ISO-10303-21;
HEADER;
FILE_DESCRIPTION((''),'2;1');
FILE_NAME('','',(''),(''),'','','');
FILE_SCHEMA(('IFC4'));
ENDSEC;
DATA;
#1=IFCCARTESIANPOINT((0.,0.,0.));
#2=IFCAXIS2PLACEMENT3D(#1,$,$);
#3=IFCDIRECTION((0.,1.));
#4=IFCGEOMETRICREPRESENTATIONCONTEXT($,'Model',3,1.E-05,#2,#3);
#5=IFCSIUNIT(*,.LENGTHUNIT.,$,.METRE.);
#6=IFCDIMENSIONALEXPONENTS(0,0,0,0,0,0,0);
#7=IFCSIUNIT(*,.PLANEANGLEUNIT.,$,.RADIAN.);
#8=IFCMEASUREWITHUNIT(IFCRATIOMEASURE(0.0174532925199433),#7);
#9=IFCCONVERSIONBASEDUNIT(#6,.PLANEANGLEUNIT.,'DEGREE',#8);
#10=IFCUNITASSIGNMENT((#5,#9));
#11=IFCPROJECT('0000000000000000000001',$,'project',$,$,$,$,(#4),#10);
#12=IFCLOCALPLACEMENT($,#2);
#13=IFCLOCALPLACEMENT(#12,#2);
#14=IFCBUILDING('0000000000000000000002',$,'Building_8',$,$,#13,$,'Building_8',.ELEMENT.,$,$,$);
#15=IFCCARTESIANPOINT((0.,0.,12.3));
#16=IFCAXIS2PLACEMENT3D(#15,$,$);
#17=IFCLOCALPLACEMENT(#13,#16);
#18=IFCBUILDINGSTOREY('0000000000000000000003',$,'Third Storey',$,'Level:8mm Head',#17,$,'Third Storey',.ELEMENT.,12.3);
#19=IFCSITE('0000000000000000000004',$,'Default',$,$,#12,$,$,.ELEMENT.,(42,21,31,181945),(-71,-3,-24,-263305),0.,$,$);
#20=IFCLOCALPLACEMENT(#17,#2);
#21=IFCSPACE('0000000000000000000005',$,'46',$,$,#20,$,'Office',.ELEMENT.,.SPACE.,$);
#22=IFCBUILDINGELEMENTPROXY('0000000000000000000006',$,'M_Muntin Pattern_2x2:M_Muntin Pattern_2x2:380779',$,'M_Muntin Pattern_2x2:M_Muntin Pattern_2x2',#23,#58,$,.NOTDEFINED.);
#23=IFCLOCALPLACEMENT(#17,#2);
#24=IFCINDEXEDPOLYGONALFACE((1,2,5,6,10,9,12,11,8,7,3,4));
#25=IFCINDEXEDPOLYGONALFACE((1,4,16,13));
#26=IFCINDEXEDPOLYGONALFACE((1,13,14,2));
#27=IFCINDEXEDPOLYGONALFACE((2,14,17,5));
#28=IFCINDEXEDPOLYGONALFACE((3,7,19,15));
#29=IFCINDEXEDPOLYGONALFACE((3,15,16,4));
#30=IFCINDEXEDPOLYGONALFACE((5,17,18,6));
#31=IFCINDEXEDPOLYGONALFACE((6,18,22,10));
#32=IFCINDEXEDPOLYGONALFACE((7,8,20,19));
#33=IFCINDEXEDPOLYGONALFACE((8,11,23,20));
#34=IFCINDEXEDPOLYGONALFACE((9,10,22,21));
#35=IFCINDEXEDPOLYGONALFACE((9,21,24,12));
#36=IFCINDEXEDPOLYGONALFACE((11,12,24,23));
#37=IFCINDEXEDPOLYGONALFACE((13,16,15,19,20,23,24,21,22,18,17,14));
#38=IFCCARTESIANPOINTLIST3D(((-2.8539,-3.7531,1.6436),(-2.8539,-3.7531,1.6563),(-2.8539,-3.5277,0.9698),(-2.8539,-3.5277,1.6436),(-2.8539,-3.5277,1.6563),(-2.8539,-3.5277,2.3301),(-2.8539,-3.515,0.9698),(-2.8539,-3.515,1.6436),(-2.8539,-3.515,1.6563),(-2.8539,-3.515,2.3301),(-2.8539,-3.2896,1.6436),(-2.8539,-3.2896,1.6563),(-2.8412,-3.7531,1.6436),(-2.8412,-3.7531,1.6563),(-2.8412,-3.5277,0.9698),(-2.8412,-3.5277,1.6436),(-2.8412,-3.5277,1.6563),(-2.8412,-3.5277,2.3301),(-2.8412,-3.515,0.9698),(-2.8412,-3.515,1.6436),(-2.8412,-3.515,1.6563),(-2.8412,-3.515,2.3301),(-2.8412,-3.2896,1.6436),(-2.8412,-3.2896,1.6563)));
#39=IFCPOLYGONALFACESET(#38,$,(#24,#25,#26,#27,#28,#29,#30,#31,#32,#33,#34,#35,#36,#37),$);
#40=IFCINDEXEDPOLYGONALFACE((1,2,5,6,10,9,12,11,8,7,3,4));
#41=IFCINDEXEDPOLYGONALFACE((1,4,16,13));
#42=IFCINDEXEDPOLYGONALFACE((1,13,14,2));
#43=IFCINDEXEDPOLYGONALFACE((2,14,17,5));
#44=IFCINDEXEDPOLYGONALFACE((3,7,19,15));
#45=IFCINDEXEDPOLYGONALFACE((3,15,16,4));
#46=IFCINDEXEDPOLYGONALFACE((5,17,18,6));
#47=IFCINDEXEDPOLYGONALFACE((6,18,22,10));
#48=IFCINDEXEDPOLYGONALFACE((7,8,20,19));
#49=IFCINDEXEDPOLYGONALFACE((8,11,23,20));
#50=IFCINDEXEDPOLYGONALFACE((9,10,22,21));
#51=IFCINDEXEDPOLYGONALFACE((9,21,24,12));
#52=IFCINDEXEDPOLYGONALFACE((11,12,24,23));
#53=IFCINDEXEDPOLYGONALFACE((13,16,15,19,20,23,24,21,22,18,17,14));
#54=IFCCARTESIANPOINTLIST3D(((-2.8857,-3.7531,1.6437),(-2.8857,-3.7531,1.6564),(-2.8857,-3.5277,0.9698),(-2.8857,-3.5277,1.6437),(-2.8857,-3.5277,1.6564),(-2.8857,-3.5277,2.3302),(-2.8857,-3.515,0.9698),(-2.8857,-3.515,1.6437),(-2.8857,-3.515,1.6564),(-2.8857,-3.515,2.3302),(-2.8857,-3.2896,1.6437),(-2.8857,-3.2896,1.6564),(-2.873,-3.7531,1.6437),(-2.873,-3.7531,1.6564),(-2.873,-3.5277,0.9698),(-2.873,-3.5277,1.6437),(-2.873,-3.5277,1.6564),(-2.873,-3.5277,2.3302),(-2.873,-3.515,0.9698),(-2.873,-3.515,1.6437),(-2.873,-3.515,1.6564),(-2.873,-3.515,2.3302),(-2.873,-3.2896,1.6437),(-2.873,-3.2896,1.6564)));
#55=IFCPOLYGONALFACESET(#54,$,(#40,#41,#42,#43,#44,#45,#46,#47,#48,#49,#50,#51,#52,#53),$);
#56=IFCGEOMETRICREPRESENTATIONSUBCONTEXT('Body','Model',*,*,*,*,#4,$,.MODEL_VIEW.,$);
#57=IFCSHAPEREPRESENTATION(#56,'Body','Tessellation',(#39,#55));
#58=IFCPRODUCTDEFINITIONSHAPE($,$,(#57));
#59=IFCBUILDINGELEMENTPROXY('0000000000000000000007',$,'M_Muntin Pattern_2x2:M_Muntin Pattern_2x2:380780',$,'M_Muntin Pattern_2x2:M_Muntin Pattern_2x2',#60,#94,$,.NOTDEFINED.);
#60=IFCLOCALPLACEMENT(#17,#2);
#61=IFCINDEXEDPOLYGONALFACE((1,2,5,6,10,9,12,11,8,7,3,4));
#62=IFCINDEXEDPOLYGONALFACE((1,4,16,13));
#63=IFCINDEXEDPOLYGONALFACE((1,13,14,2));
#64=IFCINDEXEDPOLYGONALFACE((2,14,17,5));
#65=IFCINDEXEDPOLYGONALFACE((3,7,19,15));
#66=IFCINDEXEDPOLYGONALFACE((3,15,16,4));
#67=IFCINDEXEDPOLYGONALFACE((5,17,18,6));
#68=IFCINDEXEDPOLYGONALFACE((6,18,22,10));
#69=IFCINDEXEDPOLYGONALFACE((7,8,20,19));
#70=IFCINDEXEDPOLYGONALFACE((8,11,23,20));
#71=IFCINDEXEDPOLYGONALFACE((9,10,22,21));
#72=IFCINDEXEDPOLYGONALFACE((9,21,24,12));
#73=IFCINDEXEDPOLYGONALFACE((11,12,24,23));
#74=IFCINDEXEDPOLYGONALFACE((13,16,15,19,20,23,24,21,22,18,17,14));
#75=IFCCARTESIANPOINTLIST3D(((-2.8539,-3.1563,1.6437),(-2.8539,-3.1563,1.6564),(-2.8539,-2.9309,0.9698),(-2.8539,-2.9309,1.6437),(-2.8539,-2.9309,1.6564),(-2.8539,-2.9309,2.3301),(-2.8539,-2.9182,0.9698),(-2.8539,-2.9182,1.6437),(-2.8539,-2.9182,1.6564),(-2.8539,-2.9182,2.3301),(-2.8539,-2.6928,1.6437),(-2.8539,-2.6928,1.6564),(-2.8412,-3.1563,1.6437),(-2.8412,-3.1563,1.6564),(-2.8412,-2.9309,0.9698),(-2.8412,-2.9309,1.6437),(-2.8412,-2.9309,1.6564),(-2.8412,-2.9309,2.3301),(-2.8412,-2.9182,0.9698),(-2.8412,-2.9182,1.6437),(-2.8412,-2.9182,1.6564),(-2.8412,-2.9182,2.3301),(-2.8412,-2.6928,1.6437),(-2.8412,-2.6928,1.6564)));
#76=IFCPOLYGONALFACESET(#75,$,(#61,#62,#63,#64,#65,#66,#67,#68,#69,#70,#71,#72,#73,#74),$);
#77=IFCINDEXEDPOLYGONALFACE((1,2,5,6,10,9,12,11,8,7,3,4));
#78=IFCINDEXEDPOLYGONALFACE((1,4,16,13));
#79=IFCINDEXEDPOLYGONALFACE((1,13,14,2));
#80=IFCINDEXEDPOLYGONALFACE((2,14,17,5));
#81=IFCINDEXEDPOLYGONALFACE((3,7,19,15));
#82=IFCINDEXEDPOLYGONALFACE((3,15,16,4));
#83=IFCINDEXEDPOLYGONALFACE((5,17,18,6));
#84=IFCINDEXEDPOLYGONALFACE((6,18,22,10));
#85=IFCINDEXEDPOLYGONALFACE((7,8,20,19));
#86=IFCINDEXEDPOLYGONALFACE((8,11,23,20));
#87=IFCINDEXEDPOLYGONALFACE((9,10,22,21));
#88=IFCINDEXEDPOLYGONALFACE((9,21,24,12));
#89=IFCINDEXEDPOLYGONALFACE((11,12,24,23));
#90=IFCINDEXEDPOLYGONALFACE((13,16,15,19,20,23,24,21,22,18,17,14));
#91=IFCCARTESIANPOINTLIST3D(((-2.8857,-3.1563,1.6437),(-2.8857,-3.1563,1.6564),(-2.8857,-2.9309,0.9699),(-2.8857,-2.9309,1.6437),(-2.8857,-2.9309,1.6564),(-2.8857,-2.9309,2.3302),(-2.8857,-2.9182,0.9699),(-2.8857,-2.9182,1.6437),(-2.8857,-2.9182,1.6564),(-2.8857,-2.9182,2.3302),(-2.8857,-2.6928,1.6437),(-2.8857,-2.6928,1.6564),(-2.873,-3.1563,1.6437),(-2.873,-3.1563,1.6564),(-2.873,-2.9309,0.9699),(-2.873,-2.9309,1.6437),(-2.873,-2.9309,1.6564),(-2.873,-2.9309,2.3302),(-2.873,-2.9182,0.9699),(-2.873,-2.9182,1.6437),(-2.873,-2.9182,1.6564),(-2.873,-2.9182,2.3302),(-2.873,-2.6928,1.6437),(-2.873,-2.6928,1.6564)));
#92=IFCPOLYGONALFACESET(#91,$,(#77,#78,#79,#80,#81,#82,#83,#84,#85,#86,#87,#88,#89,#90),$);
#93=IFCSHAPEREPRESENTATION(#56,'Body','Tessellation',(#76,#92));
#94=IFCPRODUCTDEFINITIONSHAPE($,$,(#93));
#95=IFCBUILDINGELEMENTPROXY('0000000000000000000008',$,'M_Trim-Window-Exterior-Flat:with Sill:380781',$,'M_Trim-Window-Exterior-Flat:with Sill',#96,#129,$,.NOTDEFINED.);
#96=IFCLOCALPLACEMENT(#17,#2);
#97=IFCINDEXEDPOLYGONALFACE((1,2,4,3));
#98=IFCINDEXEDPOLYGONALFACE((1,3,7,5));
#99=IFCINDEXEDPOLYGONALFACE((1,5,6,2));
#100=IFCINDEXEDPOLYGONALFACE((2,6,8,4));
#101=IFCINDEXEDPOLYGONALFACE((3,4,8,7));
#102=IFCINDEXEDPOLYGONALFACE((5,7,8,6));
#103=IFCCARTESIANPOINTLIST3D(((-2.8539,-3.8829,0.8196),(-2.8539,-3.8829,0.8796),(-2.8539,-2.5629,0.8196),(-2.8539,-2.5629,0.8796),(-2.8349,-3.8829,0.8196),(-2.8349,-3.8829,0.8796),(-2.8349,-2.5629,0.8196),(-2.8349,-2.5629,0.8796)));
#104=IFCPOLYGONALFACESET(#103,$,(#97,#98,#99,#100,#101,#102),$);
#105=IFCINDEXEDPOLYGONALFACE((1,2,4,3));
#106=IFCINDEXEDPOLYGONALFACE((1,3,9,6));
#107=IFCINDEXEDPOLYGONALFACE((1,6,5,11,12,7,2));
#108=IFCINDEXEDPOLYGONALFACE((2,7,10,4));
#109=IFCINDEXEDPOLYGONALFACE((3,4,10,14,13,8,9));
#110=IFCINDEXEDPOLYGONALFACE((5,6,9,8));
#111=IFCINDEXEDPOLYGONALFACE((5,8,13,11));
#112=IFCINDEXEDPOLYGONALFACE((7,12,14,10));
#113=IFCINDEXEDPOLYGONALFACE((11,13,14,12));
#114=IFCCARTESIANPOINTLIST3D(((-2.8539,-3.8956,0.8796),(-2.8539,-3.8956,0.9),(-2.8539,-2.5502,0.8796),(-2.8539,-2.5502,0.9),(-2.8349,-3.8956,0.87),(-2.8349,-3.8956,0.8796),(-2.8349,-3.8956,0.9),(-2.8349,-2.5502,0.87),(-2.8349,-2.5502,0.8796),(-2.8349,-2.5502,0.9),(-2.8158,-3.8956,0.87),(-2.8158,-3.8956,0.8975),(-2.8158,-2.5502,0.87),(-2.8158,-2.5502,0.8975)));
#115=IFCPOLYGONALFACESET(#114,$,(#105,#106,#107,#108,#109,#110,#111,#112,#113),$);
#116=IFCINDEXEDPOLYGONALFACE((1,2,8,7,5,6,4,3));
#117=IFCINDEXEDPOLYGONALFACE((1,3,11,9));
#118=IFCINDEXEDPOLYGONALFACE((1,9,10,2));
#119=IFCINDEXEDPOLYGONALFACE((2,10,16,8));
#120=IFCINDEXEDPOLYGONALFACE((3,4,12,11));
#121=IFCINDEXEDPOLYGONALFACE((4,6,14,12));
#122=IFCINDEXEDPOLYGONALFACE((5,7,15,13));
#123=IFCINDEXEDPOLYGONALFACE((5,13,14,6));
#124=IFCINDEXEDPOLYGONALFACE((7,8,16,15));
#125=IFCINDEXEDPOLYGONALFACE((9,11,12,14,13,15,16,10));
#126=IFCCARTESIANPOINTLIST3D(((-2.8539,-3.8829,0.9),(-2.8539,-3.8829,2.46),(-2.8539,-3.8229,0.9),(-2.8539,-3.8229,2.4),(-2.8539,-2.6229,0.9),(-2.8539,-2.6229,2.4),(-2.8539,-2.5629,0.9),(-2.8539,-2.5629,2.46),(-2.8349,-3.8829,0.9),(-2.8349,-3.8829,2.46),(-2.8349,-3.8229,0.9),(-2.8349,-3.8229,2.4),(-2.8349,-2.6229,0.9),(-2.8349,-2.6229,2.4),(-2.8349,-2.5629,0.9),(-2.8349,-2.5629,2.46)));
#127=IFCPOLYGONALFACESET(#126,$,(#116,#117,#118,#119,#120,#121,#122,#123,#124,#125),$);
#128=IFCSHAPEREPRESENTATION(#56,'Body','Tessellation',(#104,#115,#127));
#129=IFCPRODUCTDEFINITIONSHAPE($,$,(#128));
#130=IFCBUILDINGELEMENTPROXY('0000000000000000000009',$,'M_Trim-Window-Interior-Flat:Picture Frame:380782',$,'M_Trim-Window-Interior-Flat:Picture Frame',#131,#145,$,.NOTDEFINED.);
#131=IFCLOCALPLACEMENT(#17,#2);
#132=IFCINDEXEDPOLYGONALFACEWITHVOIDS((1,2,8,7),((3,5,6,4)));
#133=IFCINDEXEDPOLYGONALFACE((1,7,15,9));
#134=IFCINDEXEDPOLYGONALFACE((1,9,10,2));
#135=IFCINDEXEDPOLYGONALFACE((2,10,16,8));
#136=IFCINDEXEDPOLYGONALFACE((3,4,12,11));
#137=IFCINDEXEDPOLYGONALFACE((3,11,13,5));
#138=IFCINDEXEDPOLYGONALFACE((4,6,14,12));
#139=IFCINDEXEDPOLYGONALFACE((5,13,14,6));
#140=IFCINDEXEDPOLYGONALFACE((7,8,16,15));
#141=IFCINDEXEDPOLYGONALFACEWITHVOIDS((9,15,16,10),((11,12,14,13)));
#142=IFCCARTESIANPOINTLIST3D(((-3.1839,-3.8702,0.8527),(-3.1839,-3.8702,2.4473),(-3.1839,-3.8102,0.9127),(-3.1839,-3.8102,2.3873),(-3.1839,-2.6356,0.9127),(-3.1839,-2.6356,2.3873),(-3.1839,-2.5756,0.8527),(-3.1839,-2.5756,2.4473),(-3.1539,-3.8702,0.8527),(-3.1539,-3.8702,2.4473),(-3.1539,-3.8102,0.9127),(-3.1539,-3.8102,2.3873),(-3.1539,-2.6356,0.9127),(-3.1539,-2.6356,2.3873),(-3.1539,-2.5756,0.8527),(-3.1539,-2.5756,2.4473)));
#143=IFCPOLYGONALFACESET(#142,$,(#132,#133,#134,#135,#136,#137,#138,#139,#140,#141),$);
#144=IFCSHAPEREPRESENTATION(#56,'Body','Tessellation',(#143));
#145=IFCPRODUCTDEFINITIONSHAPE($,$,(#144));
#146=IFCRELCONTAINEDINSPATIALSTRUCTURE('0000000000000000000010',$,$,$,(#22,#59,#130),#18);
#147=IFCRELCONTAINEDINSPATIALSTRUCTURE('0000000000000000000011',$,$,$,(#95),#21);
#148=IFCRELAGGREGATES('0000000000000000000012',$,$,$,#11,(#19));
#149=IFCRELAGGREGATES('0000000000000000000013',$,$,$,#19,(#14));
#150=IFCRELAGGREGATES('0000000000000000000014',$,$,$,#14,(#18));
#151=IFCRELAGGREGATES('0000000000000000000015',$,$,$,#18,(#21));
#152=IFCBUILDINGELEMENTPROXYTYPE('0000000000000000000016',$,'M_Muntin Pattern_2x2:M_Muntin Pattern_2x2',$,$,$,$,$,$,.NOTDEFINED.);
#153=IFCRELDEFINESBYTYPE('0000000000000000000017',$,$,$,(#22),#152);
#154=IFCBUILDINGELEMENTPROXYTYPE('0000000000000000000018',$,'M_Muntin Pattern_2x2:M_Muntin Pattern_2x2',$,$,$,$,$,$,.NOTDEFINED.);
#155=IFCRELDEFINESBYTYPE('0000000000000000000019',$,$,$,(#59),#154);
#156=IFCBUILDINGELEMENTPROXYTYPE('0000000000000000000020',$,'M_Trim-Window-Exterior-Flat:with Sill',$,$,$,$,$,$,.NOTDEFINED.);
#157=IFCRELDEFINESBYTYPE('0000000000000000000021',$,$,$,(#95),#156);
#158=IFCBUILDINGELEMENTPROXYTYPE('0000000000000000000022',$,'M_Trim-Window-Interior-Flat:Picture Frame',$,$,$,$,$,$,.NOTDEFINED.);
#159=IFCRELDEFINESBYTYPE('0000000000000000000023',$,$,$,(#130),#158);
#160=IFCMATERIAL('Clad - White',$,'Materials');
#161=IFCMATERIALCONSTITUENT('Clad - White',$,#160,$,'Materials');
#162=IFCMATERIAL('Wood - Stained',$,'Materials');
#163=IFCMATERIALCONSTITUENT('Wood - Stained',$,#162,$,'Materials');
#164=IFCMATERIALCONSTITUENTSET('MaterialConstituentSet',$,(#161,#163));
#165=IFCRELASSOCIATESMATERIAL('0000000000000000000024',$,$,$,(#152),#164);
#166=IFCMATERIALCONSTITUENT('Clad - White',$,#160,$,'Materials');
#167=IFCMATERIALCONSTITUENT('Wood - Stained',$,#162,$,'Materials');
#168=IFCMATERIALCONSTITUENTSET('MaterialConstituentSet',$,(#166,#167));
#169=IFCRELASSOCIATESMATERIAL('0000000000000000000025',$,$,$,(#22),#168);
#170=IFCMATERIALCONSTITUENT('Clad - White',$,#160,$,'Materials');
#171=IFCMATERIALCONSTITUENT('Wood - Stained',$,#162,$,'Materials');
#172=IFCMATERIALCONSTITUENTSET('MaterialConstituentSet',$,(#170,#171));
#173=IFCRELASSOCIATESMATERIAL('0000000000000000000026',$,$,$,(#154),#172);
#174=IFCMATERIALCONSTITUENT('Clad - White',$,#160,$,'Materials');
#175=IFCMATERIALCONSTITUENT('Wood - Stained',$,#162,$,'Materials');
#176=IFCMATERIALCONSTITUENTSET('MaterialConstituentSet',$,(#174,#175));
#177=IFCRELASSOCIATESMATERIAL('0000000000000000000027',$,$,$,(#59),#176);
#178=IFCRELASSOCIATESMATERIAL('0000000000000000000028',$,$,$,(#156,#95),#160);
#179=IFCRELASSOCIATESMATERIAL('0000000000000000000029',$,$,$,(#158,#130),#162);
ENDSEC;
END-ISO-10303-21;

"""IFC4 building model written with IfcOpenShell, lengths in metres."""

from ifc_helpers import new_model, entity, si_unit, converted_unit, direction, frame, origin, place, context, subcontext, project, spatial, indexed_curve, outline, extrude, source, transform, mapped, material, constituent, constituent_set, type_object, type_shapes, element, save


model = new_model("IFC4")

# Units and contexts
model_context = context("Model", 3, precision=1e-05, world=origin(), true_north=direction((0.0, 1.0)))
body_context = subcontext(model_context, "Body", "Model", "MODEL_VIEW")
ifc_project = project(units=[si_unit("LENGTHUNIT", "METRE"), converted_unit("PLANEANGLEUNIT", "DEGREE", entity("IfcRatioMeasure", 0.0174532925199433), si_unit("PLANEANGLEUNIT", "RADIAN"), dimensions=[0, 0, 0, 0, 0, 0, 0])], contexts=[model_context])

# Site, building, storey
site_placement = place(None, origin())
site = spatial("IfcSite", under=ifc_project, at=site_placement, Name="Default", CompositionType="ELEMENT", RefLatitude=(42, 21, 31, 181945), RefLongitude=(-71, -3, -24, -263305), RefElevation=0.0)
building_placement = place(site_placement, origin())
building = spatial("IfcBuilding", under=site, at=building_placement, Name="Building_8", LongName="Building_8", CompositionType="ELEMENT")
storey_placement = place(building_placement, frame((0.0, 0.0, 12.3)))
storey = spatial("IfcBuildingStorey", under=building, at=storey_placement, Name="Third Storey", ObjectType="Level:8mm Head", LongName="Third Storey", CompositionType="ELEMENT", Elevation=12.3)

# Shared definitions
ifc_material_1 = material(Name="Clad - White", Category="Materials")
ifc_material_2 = material(Name="Wood - Stained", Category="Materials")

# Building element proxies
ifc_constituent_1 = constituent(ifc_material_1, Name="Clad - White", Category="Materials")
ifc_constituent_2 = constituent(ifc_material_2, Name="Wood - Stained", Category="Materials")
ifc_constituent_set_1 = constituent_set(constituents=[ifc_constituent_1, ifc_constituent_2], Name="MaterialConstituentSet")
ifc_constituent_3 = constituent(ifc_material_1, Name="Clad - White", Category="Materials")
ifc_constituent_4 = constituent(ifc_material_2, Name="Wood - Stained", Category="Materials")
ifc_constituent_set_2 = constituent_set(constituents=[ifc_constituent_3, ifc_constituent_4], Name="MaterialConstituentSet")
building_element_proxy_type_1 = type_object("IfcBuildingElementProxyType", Name="M_Muntin Pattern_2x2:M_Muntin Pattern_2x2", PredefinedType="NOTDEFINED", material=ifc_constituent_set_2)
shared_shape_1 = source(origin(), body_context, "Body", "SweptSolid", [
    extrude(outline(indexed_curve([(0.0064, -0.0064), (0.6801, -0.0064), (0.6801, 0.0063), (0.0064, 0.0063), (0.0064, 0.2317), (-0.0063, 0.2317), (-0.0063, 0.0063), (-0.6802, 0.0063), (-0.6802, -0.0064), (-0.0063, -0.0064), (-0.0063, -0.2317), (0.0064, -0.2317), (0.0064, -0.0064)], self_intersect=False)), frame((0.0, -0.0222, 0.6801), z_axis=(0.0, 1.0, 0.0), x_axis=(0.0, 0.0, 1.0)), (0.0, 0.0, 1.0), 0.0127),
    extrude(outline(indexed_curve([(0.0064, -0.0064), (0.6802, -0.0064), (0.6802, 0.0063), (0.0064, 0.0063), (0.0064, 0.2317), (-0.0063, 0.2317), (-0.0063, 0.0063), (-0.6802, 0.0063), (-0.6802, -0.0064), (-0.0063, -0.0064), (-0.0063, -0.2317), (0.0064, -0.2317), (0.0064, -0.0064)], self_intersect=False)), frame((0.0, 0.0095, 0.6802), z_axis=(0.0, 1.0, 0.0), x_axis=(0.0, 0.0, 1.0)), (0.0, 0.0, 1.0), 0.0127),
])
type_shapes(building_element_proxy_type_1, [shared_shape_1])
proxy_1_placement = place(storey_placement, frame((-2.8634, -3.5213, 0.9698), z_axis=(0.0, 0.0, 1.0), x_axis=(0.0, 1.0, 0.0)))
element("IfcBuildingElementProxy", 1, at=proxy_1_placement, inside=storey, type_object=building_element_proxy_type_1, material=ifc_constituent_set_1, Name="M_Muntin Pattern_2x2:M_Muntin Pattern_2x2:380779", ObjectType="M_Muntin Pattern_2x2:M_Muntin Pattern_2x2", PredefinedType="NOTDEFINED", context=body_context, shape_type="MappedRepresentation", body=[
    mapped(shared_shape_1, transform((0.0, 0.0, 0.0), scale=1.0)),
])
ifc_constituent_5 = constituent(ifc_material_1, Name="Clad - White", Category="Materials")
ifc_constituent_6 = constituent(ifc_material_2, Name="Wood - Stained", Category="Materials")
ifc_constituent_set_3 = constituent_set(constituents=[ifc_constituent_5, ifc_constituent_6], Name="MaterialConstituentSet")
ifc_constituent_7 = constituent(ifc_material_1, Name="Clad - White", Category="Materials")
ifc_constituent_8 = constituent(ifc_material_2, Name="Wood - Stained", Category="Materials")
ifc_constituent_set_4 = constituent_set(constituents=[ifc_constituent_7, ifc_constituent_8], Name="MaterialConstituentSet")
building_element_proxy_type_2 = type_object("IfcBuildingElementProxyType", Name="M_Muntin Pattern_2x2:M_Muntin Pattern_2x2", PredefinedType="NOTDEFINED", material=ifc_constituent_set_4)
shared_shape_2 = source(origin(), body_context, "Body", "SweptSolid", [
    extrude(outline(indexed_curve([(0.0064, -0.0064), (0.6801, -0.0064), (0.6801, 0.0063), (0.0064, 0.0063), (0.0064, 0.2317), (-0.0063, 0.2317), (-0.0063, 0.0063), (-0.6802, 0.0063), (-0.6802, -0.0064), (-0.0063, -0.0064), (-0.0063, -0.2317), (0.0064, -0.2317), (0.0064, -0.0064)], self_intersect=False)), frame((0.0, 0.0095, 0.6801), z_axis=(0.0, 1.0, 0.0), x_axis=(0.0, 0.0, 1.0)), (0.0, 0.0, 1.0), 0.0127),
    extrude(outline(indexed_curve([(0.0064, -0.0064), (0.6802, -0.0064), (0.6802, 0.0063), (0.0064, 0.0063), (0.0064, 0.2317), (-0.0063, 0.2317), (-0.0063, 0.0063), (-0.6802, 0.0063), (-0.6802, -0.0064), (-0.0063, -0.0064), (-0.0063, -0.2317), (0.0064, -0.2317), (0.0064, -0.0064)], self_intersect=False)), frame((0.0, -0.0222, 0.6802), z_axis=(0.0, 1.0, 0.0), x_axis=(0.0, 0.0, 1.0)), (0.0, 0.0, 1.0), 0.0127),
])
type_shapes(building_element_proxy_type_2, [shared_shape_2])
proxy_2_placement = place(storey_placement, frame((-2.8634, -2.9245, 0.9699), z_axis=(0.0, 0.0, 1.0), x_axis=(0.0, -1.0, 0.0)))
element("IfcBuildingElementProxy", 2, at=proxy_2_placement, inside=storey, type_object=building_element_proxy_type_2, material=ifc_constituent_set_3, Name="M_Muntin Pattern_2x2:M_Muntin Pattern_2x2:380780", ObjectType="M_Muntin Pattern_2x2:M_Muntin Pattern_2x2", PredefinedType="NOTDEFINED", context=body_context, shape_type="MappedRepresentation", body=[
    mapped(shared_shape_2, transform((0.0, 0.0, 0.0), scale=1.0)),
])

# Shared definitions
space_1_placement = place(storey_placement, origin())
space_1 = spatial("IfcSpace", under=storey, at=space_1_placement, Name="46", LongName="Office", CompositionType="ELEMENT", PredefinedType="SPACE")

# Building element proxies
building_element_proxy_type_3 = type_object("IfcBuildingElementProxyType", Name="M_Trim-Window-Exterior-Flat:with Sill", PredefinedType="NOTDEFINED", material=ifc_material_1)
shared_shape_3 = source(origin(), body_context, "Body", "SweptSolid", [
    extrude(outline(indexed_curve([(-0.03, -0.66), (0.03, -0.66), (0.03, 0.66), (-0.03, 0.66), (-0.03, -0.66)], self_intersect=False)), frame((0.0, 1.5504, 0.0), z_axis=(0.0, 0.0, 1.0), x_axis=(0.0, 1.0, 0.0)), (0.0, 0.0, 1.0), 0.0191),
    extrude(outline(indexed_curve([(-0.0152, -0.019), (0.0123, -0.019), (0.0148, 0.0), (0.0148, 0.019), (-0.0057, 0.019), (-0.0057, 0.0), (-0.0152, 0.0), (-0.0152, -0.019)], self_intersect=False)), frame((-0.6727, 1.5148, 0.019), z_axis=(1.0, 0.0, 0.0), x_axis=(0.0, -1.0, 0.0)), (0.0, 0.0, 1.0), 1.3454),
    extrude(outline(indexed_curve([(-0.66, -0.795), (0.66, -0.795), (0.66, 0.765), (0.6, 0.765), (0.6, -0.735), (-0.6, -0.735), (-0.6, 0.765), (-0.66, 0.765), (-0.66, -0.795)], self_intersect=False)), frame((0.0, 0.735, 0.0)), (0.0, 0.0, 1.0), 0.0191),
])
type_shapes(building_element_proxy_type_3, [shared_shape_3])
proxy_3_placement = place(space_1_placement, frame((-2.8539, -3.2229, 2.4), z_axis=(1.0, 0.0, 0.0), x_axis=(0.0, -1.0, 0.0)))
element("IfcBuildingElementProxy", 3, at=proxy_3_placement, inside=space_1, type_object=building_element_proxy_type_3, material=ifc_material_1, Name="M_Trim-Window-Exterior-Flat:with Sill:380781", ObjectType="M_Trim-Window-Exterior-Flat:with Sill", PredefinedType="NOTDEFINED", context=body_context, shape_type="MappedRepresentation", body=[
    mapped(shared_shape_3, transform((0.0, 0.0, 0.0), scale=1.0)),
])
building_element_proxy_type_4 = type_object("IfcBuildingElementProxyType", Name="M_Trim-Window-Interior-Flat:Picture Frame", PredefinedType="NOTDEFINED", material=ifc_material_2)
shared_shape_4 = source(origin(), body_context, "Body", "SweptSolid", [
    extrude(outline(indexed_curve([(-0.7973, -0.6473), (0.7973, -0.6473), (0.7973, 0.6473), (-0.7973, 0.6473), (-0.7973, -0.6473)], self_intersect=False), holes=[indexed_curve([(-0.7373, -0.5873), (-0.7373, 0.5873), (0.7373, 0.5873), (0.7373, -0.5873), (-0.7373, -0.5873)], self_intersect=False)]), frame((0.0, 0.75, 0.0), z_axis=(0.0, 0.0, 1.0), x_axis=(0.0, 1.0, 0.0)), (0.0, 0.0, 1.0), 0.03),
])
type_shapes(building_element_proxy_type_4, [shared_shape_4])
proxy_4_placement = place(storey_placement, frame((-3.1539, -3.2229, 2.4), z_axis=(-1.0, 0.0, 0.0), x_axis=(0.0, 1.0, 0.0)))
element("IfcBuildingElementProxy", 4, at=proxy_4_placement, inside=storey, type_object=building_element_proxy_type_4, material=ifc_material_2, Name="M_Trim-Window-Interior-Flat:Picture Frame:380782", ObjectType="M_Trim-Window-Interior-Flat:Picture Frame", PredefinedType="NOTDEFINED", context=body_context, shape_type="MappedRepresentation", body=[
    mapped(shared_shape_4, transform((0.0, 0.0, 0.0), scale=1.0)),
])

save(model, "model.ifc")
